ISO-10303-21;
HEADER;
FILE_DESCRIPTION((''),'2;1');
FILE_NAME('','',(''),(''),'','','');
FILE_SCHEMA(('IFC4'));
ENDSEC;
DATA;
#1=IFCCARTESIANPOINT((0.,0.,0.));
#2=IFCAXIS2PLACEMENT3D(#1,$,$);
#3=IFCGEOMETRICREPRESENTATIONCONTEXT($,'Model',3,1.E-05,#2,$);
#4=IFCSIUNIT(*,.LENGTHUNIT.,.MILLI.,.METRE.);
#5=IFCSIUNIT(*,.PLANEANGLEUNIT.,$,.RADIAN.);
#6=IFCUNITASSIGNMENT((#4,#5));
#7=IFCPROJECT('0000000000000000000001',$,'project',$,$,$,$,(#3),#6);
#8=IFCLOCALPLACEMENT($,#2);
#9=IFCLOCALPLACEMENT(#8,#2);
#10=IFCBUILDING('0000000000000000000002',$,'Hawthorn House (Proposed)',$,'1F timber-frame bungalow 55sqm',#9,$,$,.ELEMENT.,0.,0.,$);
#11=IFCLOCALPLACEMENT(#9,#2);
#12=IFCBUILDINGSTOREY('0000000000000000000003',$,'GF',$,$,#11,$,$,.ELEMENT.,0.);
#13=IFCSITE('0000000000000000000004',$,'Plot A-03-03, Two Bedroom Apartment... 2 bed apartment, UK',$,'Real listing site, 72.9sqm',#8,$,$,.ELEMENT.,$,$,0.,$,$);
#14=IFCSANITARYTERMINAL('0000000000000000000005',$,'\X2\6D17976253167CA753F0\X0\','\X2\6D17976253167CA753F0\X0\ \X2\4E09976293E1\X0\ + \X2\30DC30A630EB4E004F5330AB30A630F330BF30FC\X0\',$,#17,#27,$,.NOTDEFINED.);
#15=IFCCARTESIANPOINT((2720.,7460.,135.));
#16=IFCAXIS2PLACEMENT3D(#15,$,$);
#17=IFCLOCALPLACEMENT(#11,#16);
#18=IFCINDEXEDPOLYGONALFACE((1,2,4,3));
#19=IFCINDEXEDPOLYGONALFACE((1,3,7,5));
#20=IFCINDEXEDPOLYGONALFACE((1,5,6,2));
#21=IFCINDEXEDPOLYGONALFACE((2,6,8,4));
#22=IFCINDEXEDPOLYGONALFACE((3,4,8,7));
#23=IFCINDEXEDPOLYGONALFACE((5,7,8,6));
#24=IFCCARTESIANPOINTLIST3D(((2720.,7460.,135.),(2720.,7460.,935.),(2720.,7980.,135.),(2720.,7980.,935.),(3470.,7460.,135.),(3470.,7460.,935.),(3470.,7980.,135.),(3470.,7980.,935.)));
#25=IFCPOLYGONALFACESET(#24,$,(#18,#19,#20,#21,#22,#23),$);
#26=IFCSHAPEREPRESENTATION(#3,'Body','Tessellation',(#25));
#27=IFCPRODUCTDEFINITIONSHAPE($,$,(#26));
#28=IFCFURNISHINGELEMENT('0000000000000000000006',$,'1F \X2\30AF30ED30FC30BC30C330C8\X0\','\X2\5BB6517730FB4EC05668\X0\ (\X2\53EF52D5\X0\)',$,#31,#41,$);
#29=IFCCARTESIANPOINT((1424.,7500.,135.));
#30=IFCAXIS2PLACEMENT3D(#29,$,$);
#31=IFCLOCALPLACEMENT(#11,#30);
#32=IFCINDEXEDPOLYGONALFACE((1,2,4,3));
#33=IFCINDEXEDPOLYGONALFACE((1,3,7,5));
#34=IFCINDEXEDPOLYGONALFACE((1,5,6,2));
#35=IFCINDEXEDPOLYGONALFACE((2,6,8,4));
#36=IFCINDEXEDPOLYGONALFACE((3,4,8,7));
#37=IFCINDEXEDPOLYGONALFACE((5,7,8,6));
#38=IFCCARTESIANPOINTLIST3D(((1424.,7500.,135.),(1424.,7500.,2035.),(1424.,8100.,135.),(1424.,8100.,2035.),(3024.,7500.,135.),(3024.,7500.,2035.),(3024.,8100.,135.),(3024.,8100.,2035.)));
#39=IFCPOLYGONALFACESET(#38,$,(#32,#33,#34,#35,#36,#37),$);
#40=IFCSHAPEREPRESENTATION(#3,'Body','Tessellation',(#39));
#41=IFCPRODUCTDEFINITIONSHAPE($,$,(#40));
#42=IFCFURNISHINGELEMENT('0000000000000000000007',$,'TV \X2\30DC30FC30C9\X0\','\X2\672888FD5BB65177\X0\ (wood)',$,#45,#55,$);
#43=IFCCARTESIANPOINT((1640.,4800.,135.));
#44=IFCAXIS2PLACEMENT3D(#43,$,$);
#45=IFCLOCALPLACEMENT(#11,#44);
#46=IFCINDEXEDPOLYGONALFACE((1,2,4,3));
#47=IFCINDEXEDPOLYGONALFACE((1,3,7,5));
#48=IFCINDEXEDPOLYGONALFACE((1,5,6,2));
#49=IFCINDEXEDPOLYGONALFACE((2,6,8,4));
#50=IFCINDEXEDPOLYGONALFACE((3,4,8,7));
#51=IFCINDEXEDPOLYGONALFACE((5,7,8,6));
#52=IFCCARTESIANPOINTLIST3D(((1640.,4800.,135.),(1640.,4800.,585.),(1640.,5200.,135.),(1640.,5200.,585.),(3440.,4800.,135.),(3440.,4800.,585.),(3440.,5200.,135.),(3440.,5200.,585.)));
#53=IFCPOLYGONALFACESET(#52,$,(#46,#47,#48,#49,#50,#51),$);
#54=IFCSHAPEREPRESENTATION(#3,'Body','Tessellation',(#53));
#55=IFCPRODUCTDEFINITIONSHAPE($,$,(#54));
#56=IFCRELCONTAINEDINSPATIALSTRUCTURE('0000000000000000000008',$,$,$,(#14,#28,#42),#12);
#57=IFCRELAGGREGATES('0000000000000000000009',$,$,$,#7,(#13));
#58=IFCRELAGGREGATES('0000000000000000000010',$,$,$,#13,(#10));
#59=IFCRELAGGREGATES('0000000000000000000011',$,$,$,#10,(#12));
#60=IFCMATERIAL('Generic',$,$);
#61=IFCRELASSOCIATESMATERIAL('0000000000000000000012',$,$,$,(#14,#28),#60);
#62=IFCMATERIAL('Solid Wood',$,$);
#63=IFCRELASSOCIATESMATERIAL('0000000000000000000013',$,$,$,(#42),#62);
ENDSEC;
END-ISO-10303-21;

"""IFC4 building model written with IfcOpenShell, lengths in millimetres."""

from ifc_helpers import new_model, si_unit, frame, frame_2d, origin, place, context, project, spatial, rectangle, extrude, material, element, save


model = new_model("IFC4")

# Units and contexts
model_context = context("Model", 3, precision=1e-05, world=origin())
ifc_project = project(units=[si_unit("LENGTHUNIT", "METRE", prefix="MILLI"), si_unit("PLANEANGLEUNIT", "RADIAN")], contexts=[model_context])

# Site, building, storey
site_placement = place(None, origin())
site = spatial("IfcSite", under=ifc_project, at=site_placement, Name="Plot A-03-03, Two Bedroom Apartment... 2 bed apartment, UK", ObjectType="Real listing site, 72.9sqm", CompositionType="ELEMENT", RefElevation=0.0)
building_placement = place(site_placement, origin())
building = spatial("IfcBuilding", under=site, at=building_placement, Name="Hawthorn House (Proposed)", ObjectType="1F timber-frame bungalow 55sqm", CompositionType="ELEMENT", ElevationOfRefHeight=0.0, ElevationOfTerrain=0.0)
storey_placement = place(building_placement, origin())
storey = spatial("IfcBuildingStorey", under=building, at=storey_placement, Name="GF", CompositionType="ELEMENT", Elevation=0.0)

# Shared definitions
ifc_material_1 = material(Name="Solid Wood")

# Shared definitions
ifc_material_2 = material(Name="Generic")

# Sanitary terminal
sanitary_terminal_1_placement = place(storey_placement, frame((2720.0, 7460.0, 135.0)))
element("IfcSanitaryTerminal", 1, at=sanitary_terminal_1_placement, inside=storey, material=ifc_material_2, Name="洗面化粧台", Description="洗面化粧台 三面鏡 + ボウル一体カウンター", PredefinedType="NOTDEFINED", context=model_context, shape_type="SweptSolid", body=[
    extrude(rectangle(XDim=750.0, YDim=520.0, at=frame_2d((375.0, 260.0))), frame((2720.0, 7460.0, 135.0)), (0.0, 0.0, 1.0), 800.0),
])

# Furnishing elements
furnishing_1_placement = place(storey_placement, frame((1424.0, 7500.0, 135.0)))
element("IfcFurnishingElement", 2, at=furnishing_1_placement, inside=storey, material=ifc_material_2, Name="1F クローゼット", Description="家具・什器 (可動)", context=model_context, shape_type="SweptSolid", body=[
    extrude(rectangle(XDim=1600.0, YDim=600.0, at=frame_2d((800.0, 300.0))), frame((1424.0, 7500.0, 135.0)), (0.0, 0.0, 1.0), 1900.0),
])
furnishing_2_placement = place(storey_placement, frame((1640.0, 4800.0, 135.0)))
element("IfcFurnishingElement", 3, at=furnishing_2_placement, inside=storey, material=ifc_material_1, Name="TV ボード", Description="木製家具 (wood)", context=model_context, shape_type="SweptSolid", body=[
    extrude(rectangle(XDim=1800.0, YDim=400.0, at=frame_2d((900.0, 200.0))), frame((1640.0, 4800.0, 135.0)), (0.0, 0.0, 1.0), 450.0),
])

save(model, "model.ifc")
